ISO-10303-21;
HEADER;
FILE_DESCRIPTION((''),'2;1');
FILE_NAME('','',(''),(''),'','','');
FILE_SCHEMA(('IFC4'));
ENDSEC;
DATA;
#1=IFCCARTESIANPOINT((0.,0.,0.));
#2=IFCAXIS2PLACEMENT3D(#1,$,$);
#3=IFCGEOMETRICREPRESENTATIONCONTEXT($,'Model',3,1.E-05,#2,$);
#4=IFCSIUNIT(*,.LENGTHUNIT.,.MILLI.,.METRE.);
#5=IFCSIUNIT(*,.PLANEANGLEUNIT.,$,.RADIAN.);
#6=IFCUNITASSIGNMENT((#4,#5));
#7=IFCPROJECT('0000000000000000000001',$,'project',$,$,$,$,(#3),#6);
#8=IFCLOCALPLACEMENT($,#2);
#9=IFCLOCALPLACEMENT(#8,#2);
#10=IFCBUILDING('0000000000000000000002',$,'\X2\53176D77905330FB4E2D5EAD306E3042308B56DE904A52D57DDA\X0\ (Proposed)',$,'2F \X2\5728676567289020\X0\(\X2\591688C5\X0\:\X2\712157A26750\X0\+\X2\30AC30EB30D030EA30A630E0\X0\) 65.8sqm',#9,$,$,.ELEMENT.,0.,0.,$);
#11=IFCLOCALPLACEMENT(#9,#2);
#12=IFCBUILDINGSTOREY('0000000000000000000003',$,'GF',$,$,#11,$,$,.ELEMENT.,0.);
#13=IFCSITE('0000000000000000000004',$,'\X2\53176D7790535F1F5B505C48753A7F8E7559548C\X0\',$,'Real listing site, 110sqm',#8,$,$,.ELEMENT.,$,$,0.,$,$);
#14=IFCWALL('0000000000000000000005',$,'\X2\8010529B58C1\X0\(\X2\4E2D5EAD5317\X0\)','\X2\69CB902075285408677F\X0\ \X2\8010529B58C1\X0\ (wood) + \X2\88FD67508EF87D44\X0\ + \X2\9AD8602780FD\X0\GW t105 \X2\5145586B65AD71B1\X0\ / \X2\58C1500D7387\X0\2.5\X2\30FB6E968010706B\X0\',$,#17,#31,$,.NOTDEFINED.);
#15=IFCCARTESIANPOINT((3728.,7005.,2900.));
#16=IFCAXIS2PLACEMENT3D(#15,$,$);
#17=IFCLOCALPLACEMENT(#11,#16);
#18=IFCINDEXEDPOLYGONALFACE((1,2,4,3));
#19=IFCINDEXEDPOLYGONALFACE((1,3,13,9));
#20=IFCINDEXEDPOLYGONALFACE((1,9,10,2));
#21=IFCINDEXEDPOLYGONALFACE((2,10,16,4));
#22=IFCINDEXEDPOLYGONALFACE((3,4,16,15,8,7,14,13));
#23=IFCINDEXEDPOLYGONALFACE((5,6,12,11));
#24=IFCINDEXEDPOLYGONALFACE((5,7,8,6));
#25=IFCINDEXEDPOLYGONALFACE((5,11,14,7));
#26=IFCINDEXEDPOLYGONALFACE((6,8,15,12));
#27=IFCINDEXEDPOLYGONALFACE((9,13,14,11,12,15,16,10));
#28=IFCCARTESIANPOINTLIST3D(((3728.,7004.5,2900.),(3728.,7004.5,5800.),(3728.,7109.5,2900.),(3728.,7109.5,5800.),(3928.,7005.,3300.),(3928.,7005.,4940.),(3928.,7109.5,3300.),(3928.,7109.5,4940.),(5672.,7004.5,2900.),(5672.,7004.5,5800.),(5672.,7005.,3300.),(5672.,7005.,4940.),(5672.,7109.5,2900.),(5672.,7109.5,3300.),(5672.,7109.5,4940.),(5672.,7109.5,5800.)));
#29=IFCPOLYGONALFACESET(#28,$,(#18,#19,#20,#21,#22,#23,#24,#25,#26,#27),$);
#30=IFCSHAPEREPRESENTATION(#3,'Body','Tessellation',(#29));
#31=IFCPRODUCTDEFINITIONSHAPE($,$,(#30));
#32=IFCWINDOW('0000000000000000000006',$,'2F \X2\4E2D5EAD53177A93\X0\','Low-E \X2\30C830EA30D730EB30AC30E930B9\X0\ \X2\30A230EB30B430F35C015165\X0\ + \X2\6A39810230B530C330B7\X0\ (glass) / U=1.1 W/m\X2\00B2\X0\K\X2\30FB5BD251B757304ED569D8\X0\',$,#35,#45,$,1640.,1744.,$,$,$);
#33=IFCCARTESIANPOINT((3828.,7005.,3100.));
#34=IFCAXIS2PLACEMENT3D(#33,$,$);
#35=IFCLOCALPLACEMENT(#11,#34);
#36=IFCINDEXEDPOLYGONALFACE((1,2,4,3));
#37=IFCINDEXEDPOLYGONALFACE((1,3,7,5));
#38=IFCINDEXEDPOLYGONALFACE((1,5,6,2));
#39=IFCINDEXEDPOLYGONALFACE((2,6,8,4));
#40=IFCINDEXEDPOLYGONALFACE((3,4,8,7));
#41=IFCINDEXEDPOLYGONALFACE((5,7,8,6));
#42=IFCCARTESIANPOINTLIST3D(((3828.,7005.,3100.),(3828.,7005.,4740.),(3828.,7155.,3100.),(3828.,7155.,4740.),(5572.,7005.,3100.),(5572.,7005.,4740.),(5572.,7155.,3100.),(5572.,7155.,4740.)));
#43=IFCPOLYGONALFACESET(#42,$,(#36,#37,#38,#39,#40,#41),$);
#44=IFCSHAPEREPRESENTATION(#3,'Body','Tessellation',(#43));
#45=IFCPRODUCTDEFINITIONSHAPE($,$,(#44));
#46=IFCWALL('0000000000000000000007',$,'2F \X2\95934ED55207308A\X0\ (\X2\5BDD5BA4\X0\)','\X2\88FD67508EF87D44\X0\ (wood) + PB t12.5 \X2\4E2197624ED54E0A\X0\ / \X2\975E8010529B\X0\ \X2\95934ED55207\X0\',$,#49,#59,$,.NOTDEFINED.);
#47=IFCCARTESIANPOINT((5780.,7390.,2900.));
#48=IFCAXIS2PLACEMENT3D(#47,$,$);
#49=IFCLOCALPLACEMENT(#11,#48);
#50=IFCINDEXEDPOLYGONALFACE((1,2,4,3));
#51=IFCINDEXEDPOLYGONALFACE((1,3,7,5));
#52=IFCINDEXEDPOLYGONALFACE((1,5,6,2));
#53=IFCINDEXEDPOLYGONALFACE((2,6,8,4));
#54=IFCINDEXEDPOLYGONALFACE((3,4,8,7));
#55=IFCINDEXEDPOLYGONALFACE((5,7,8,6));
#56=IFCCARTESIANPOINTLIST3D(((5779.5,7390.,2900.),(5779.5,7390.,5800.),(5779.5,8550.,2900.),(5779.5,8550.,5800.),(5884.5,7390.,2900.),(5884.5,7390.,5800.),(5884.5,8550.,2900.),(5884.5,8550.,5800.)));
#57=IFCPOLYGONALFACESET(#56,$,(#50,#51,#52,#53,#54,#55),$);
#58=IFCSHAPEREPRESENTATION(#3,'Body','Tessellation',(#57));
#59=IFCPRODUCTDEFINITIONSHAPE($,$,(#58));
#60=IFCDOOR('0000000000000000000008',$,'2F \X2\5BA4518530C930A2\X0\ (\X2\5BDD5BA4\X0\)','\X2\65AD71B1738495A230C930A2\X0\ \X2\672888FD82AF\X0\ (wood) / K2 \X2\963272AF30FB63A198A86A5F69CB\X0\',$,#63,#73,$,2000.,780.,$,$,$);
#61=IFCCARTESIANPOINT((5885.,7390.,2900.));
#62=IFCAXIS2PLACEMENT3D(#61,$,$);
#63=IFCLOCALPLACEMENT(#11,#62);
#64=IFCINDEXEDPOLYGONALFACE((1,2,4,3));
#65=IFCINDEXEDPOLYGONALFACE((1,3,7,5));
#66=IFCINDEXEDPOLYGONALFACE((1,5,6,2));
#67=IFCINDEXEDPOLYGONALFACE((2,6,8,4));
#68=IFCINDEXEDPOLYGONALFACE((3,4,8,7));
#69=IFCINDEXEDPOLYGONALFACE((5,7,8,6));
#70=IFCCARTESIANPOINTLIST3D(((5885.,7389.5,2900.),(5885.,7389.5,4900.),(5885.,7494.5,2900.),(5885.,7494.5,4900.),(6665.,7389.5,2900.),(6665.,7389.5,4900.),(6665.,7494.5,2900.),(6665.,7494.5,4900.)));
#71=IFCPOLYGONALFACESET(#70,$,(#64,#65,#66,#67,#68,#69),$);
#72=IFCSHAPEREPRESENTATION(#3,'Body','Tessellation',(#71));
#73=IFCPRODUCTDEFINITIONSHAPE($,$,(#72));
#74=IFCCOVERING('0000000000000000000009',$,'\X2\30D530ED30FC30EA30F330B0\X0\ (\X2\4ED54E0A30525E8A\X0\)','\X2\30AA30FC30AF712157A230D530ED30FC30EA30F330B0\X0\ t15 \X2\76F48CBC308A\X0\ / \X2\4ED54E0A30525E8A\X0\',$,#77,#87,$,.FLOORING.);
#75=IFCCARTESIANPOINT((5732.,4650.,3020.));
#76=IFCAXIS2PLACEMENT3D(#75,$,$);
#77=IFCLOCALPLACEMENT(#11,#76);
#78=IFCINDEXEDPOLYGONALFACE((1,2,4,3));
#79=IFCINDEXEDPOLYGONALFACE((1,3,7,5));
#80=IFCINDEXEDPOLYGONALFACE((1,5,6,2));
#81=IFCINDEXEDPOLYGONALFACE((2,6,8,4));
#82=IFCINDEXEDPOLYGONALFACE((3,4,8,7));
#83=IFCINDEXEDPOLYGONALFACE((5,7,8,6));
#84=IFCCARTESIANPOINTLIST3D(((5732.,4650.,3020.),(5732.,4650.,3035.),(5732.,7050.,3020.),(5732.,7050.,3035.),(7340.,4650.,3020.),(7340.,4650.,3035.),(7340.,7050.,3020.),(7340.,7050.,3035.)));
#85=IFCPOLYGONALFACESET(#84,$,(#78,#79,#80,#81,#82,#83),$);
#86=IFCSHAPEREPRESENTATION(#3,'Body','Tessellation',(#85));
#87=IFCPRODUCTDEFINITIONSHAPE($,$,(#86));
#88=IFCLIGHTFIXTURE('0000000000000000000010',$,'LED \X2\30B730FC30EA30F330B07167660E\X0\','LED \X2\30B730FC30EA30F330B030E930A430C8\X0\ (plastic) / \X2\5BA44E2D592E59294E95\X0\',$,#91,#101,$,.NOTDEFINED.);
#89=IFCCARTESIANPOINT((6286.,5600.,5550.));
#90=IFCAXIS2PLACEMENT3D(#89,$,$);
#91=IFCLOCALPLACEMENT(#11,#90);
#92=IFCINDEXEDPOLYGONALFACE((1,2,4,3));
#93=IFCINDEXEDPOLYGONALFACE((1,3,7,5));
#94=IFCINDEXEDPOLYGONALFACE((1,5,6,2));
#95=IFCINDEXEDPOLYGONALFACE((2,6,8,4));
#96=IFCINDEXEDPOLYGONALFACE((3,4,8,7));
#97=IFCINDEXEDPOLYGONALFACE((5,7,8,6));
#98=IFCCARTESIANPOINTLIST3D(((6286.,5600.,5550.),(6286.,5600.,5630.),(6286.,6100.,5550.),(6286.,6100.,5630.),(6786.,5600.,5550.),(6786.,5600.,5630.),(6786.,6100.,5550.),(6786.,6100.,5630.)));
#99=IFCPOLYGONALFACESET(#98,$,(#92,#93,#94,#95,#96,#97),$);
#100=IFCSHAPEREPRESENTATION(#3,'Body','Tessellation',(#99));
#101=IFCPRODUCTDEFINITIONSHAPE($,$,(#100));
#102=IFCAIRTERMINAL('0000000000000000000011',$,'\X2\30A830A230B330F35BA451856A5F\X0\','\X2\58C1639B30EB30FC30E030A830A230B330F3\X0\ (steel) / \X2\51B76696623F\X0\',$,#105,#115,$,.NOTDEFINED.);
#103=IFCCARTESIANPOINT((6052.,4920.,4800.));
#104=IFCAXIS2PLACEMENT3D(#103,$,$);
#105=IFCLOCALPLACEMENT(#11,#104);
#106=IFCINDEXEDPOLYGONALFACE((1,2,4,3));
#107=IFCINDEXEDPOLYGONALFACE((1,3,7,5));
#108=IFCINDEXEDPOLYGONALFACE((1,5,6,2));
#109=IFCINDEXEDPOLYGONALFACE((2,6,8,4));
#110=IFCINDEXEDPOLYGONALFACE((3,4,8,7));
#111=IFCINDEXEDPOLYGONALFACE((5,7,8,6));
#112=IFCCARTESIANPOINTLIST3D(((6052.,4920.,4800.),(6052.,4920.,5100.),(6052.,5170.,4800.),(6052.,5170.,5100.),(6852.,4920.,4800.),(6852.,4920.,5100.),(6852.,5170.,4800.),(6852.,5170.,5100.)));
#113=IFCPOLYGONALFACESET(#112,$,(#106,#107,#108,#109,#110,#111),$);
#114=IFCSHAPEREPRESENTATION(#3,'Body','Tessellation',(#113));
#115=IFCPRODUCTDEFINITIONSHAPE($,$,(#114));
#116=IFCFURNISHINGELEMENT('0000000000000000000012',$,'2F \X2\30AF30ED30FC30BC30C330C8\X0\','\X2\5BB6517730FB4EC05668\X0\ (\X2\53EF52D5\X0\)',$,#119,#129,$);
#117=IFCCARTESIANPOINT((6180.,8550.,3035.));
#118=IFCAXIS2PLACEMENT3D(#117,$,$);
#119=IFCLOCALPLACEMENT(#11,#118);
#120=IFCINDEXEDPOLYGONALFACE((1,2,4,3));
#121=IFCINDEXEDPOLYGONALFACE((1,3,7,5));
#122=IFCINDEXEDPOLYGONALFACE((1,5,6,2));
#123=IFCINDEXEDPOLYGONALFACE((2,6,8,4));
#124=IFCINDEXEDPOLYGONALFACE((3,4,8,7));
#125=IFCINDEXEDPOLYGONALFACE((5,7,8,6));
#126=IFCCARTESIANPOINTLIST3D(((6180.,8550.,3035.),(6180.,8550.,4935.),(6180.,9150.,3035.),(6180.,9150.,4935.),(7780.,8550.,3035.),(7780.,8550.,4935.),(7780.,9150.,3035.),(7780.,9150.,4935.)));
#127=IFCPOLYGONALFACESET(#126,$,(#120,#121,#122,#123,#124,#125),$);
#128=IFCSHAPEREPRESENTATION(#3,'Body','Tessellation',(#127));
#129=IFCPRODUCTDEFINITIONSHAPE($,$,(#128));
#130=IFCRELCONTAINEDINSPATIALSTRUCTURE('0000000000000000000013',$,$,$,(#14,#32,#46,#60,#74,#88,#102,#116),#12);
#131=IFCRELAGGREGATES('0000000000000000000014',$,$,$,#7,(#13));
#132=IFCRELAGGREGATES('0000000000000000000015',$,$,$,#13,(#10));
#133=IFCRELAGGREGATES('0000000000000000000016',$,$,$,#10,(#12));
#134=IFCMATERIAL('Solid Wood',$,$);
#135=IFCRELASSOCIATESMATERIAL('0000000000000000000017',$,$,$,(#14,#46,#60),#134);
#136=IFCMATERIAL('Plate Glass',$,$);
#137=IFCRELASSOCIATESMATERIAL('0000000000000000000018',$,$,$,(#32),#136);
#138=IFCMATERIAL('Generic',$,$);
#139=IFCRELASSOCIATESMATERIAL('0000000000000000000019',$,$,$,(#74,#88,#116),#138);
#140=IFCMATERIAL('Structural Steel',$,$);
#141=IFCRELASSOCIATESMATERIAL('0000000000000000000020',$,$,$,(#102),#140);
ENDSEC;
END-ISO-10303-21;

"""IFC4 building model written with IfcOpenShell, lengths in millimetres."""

from ifc_helpers import new_model, si_unit, frame, frame_2d, origin, place, context, project, spatial, rectangle, extrude, material, element, fill, save


model = new_model("IFC4")

# Units and contexts
model_context = context("Model", 3, precision=1e-05, world=origin())
ifc_project = project(units=[si_unit("LENGTHUNIT", "METRE", prefix="MILLI"), si_unit("PLANEANGLEUNIT", "RADIAN")], contexts=[model_context])

# Site, building, storey
site_placement = place(None, origin())
site = spatial("IfcSite", under=ifc_project, at=site_placement, Name="北海道弟子屈町美留和", ObjectType="Real listing site, 110sqm", CompositionType="ELEMENT", RefElevation=0.0)
building_placement = place(site_placement, origin())
building = spatial("IfcBuilding", under=site, at=building_placement, Name="北海道・中庭のある回遊動線 (Proposed)", ObjectType="2F 在来木造(外装:無垢材+ガルバリウム) 65.8sqm", CompositionType="ELEMENT", ElevationOfRefHeight=0.0, ElevationOfTerrain=0.0)
storey_placement = place(building_placement, origin())
storey = spatial("IfcBuildingStorey", under=building, at=storey_placement, Name="GF", CompositionType="ELEMENT", Elevation=0.0)

# Shared definitions
ifc_material_1 = material(Name="Solid Wood")

# Wall, opening, window
wall_1_placement = place(storey_placement, frame((3728.0, 7005.0, 2900.0)))
wall_1 = element("IfcWall", 1, at=wall_1_placement, inside=storey, material=ifc_material_1, Name="耐力壁(中庭北)", Description="構造用合板 耐力壁 (wood) + 製材軸組 + 高性能GW t105 充填断熱 / 壁倍率2.5・準耐火", PredefinedType="NOTDEFINED", context=model_context, shape_type="SweptSolid", body=[
    extrude(rectangle(XDim=1944.0, YDim=105.0, at=frame_2d((972.0, 52.0))), frame((3728.0, 7005.0, 2900.0)), (0.0, 0.0, 1.0), 2900.0),
])
opening_placement = place(storey_placement, frame((3828.0, 7005.0, 3100.0)))
opening = element("IfcOpeningElement", 2, at=opening_placement, cuts=wall_1, PredefinedType="NOTDEFINED", context=model_context, shape_type="SweptSolid", body=[
    extrude(rectangle(XDim=1744.0, YDim=150.0, at=frame_2d((872.0, 75.0))), frame((3828.0, 7005.0, 3100.0)), (0.0, 0.0, 1.0), 1640.0),
])
ifc_material_2 = material(Name="Plate Glass")
window_placement = place(storey_placement, frame((3828.0, 7005.0, 3100.0)))
window = element("IfcWindow", 3, at=window_placement, inside=storey, material=ifc_material_2, Name="2F 中庭北窓", Description="Low-E トリプルガラス アルゴン封入 + 樹脂サッシ (glass) / U=1.1 W/m²K・寒冷地仕様", OverallHeight=1640.0, OverallWidth=1744.0, context=model_context, shape_type="SweptSolid", body=[
    extrude(rectangle(XDim=1744.0, YDim=150.0, at=frame_2d((872.0, 75.0))), frame((3828.0, 7005.0, 3100.0)), (0.0, 0.0, 1.0), 1640.0),
])
fill(opening, window)

# Wall
wall_2_placement = place(storey_placement, frame((5780.0, 7390.0, 2900.0)))
element("IfcWall", 4, at=wall_2_placement, inside=storey, material=ifc_material_1, Name="2F 間仕切り (寝室)", Description="製材軸組 (wood) + PB t12.5 両面仕上 / 非耐力 間仕切", PredefinedType="NOTDEFINED", context=model_context, shape_type="SweptSolid", body=[
    extrude(rectangle(XDim=105.0, YDim=1160.0, at=frame_2d((52.0, 580.0))), frame((5780.0, 7390.0, 2900.0)), (0.0, 0.0, 1.0), 2900.0),
])

# Door
door_placement = place(storey_placement, frame((5885.0, 7390.0, 2900.0)))
element("IfcDoor", 5, at=door_placement, inside=storey, material=ifc_material_1, Name="2F 室内ドア (寝室)", Description="断熱玄関ドア 木製芯 (wood) / K2 防犯・採風機構", OverallHeight=2000.0, OverallWidth=780.0, context=model_context, shape_type="SweptSolid", body=[
    extrude(rectangle(XDim=780.0, YDim=105.0, at=frame_2d((390.0, 52.0))), frame((5885.0, 7390.0, 2900.0)), (0.0, 0.0, 1.0), 2000.0),
])

# Covering
ifc_material_3 = material(Name="Generic")
covering_placement = place(storey_placement, frame((5732.0, 4650.0, 3020.0)))
element("IfcCovering", 6, at=covering_placement, inside=storey, material=ifc_material_3, Name="フローリング (仕上げ床)", Description="オーク無垢フローリング t15 直貼り / 仕上げ床", PredefinedType="FLOORING", context=model_context, shape_type="SweptSolid", body=[
    extrude(rectangle(XDim=1608.0, YDim=2400.0, at=frame_2d((804.0, 1200.0))), frame((5732.0, 4650.0, 3020.0)), (0.0, 0.0, 1.0), 15.0),
])

# Light fixture
light_fixture_placement = place(storey_placement, frame((6286.0, 5600.0, 5550.0)))
element("IfcLightFixture", 7, at=light_fixture_placement, inside=storey, material=ifc_material_3, Name="LED シーリング照明", Description="LED シーリングライト (plastic) / 室中央天井", PredefinedType="NOTDEFINED", context=model_context, shape_type="SweptSolid", body=[
    extrude(rectangle(XDim=500.0, YDim=500.0, at=frame_2d((250.0, 250.0))), frame((6286.0, 5600.0, 5550.0)), (0.0, 0.0, 1.0), 80.0),
])

# Air terminal
ifc_material_4 = material(Name="Structural Steel")
air_terminal_placement = place(storey_placement, frame((6052.0, 4920.0, 4800.0)))
element("IfcAirTerminal", 8, at=air_terminal_placement, inside=storey, material=ifc_material_4, Name="エアコン室内機", Description="壁掛ルームエアコン (steel) / 冷暖房", PredefinedType="NOTDEFINED", context=model_context, shape_type="SweptSolid", body=[
    extrude(rectangle(XDim=800.0, YDim=250.0, at=frame_2d((400.0, 125.0))), frame((6052.0, 4920.0, 4800.0)), (0.0, 0.0, 1.0), 300.0),
])

# Furnishing element
furnishing_placement = place(storey_placement, frame((6180.0, 8550.0, 3035.0)))
element("IfcFurnishingElement", 9, at=furnishing_placement, inside=storey, material=ifc_material_3, Name="2F クローゼット", Description="家具・什器 (可動)", context=model_context, shape_type="SweptSolid", body=[
    extrude(rectangle(XDim=1600.0, YDim=600.0, at=frame_2d((800.0, 300.0))), frame((6180.0, 8550.0, 3035.0)), (0.0, 0.0, 1.0), 1900.0),
])

save(model, "model.ifc")
